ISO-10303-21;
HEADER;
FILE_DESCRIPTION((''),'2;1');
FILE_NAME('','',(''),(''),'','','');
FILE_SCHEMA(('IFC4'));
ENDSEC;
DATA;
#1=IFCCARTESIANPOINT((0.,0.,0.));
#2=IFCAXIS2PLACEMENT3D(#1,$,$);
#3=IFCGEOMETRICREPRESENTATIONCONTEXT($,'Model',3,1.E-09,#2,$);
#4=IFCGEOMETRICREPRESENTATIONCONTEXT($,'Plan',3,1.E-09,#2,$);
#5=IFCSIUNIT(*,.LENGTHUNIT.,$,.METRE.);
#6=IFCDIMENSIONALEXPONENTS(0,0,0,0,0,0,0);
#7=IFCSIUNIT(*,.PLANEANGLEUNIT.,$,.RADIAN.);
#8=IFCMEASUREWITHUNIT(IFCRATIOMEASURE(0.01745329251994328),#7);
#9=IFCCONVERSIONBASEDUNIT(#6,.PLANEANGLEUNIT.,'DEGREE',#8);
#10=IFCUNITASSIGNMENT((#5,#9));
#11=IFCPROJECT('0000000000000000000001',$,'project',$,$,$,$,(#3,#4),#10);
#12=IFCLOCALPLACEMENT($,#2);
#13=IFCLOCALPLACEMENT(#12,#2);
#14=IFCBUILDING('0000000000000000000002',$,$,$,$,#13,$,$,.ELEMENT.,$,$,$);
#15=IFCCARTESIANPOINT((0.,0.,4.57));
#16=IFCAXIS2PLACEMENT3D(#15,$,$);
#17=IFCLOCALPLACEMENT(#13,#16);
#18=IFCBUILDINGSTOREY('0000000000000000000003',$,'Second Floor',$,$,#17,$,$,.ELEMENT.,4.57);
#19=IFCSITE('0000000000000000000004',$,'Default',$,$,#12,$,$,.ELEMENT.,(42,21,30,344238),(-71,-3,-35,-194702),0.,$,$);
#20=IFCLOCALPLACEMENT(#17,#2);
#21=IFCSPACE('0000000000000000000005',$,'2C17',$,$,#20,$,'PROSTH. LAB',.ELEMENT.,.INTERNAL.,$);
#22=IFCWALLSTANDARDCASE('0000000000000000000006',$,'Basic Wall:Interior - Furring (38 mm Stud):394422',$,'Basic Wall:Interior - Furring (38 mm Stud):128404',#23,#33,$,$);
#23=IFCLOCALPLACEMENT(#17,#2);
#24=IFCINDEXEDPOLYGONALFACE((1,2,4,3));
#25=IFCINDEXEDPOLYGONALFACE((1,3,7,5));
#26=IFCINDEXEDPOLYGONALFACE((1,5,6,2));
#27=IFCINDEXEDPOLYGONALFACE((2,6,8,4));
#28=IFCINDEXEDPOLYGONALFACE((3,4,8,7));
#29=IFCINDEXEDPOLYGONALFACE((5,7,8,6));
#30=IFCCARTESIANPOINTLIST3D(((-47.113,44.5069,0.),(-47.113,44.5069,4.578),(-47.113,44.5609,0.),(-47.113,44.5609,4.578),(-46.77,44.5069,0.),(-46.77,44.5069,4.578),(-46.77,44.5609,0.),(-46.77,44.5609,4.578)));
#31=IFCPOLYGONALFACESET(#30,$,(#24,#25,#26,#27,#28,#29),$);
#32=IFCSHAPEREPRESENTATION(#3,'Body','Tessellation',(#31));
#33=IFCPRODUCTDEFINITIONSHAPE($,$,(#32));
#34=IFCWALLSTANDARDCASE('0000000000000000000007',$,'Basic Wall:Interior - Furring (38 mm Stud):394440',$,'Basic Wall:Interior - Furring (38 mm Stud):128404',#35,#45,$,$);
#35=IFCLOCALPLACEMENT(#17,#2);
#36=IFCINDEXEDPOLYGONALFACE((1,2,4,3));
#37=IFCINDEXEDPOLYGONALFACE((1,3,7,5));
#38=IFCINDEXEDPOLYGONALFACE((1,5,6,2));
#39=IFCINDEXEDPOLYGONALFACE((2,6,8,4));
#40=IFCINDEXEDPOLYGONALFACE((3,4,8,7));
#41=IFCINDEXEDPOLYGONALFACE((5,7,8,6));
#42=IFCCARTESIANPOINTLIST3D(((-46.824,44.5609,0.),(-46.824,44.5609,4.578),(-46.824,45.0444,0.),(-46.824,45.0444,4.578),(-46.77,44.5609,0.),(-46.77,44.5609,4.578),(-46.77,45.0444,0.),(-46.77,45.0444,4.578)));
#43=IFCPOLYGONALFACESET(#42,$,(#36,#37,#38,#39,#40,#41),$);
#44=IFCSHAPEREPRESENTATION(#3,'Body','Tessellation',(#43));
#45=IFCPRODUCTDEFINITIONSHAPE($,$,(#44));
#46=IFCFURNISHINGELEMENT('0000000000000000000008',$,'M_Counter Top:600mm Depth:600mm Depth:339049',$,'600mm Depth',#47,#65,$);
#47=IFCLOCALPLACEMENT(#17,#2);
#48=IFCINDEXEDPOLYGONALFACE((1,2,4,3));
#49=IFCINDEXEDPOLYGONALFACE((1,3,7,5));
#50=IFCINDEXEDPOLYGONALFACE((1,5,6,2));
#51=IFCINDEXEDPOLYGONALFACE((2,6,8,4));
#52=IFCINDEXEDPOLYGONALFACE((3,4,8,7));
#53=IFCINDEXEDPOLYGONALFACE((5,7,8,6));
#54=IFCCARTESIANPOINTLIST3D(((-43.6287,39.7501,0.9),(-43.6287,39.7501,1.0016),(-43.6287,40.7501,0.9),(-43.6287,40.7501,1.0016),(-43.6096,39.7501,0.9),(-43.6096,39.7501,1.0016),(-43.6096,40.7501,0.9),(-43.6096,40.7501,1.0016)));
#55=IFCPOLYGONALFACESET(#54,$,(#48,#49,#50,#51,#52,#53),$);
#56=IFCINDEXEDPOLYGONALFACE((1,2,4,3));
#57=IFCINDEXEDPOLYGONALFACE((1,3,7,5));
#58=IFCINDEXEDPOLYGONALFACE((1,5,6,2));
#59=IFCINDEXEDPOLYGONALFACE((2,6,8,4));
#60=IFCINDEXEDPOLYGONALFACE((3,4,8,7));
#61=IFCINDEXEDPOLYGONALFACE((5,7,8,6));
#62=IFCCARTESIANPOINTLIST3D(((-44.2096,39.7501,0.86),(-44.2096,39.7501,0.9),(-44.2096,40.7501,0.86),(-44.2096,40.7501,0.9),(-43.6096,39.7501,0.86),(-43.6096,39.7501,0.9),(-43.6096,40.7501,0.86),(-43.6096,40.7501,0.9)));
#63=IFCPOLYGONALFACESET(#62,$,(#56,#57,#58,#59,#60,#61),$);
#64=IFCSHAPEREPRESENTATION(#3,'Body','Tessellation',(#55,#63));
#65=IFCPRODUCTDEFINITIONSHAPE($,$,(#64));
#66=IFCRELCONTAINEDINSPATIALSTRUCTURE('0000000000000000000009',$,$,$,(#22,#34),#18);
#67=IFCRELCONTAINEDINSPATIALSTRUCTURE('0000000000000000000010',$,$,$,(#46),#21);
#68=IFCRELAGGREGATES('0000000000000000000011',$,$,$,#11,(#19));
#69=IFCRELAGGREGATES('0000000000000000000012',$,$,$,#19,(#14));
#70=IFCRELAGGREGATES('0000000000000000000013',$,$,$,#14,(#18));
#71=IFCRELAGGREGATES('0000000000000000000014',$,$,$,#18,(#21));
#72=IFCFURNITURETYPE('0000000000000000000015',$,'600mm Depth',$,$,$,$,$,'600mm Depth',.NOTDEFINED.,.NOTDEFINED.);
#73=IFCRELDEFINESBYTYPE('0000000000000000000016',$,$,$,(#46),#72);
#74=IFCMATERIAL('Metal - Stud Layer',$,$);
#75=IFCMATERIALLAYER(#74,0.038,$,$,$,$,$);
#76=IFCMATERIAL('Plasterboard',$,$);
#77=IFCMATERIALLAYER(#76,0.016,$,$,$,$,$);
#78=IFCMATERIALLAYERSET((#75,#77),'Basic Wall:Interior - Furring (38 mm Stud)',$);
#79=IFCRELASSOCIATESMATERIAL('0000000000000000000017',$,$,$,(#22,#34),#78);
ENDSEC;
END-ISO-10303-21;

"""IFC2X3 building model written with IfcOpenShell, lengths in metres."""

from ifc_helpers import new_model, entity, si_unit, converted_unit, frame, frame_2d, origin, origin_2d_with_axis, place, context, project, spatial, rectangle, extrude, source, transform, mapped, material, layer, layer_set, layer_usage, type_object, type_shapes, element, save


model = new_model("IFC2X3")

# Units and contexts
model_context = context("Model", 3, precision=1e-09, world=origin())
plan_context = context("Plan", 3, precision=1e-09, world=origin())
ifc_project = project(units=[si_unit("LENGTHUNIT", "METRE"), converted_unit("PLANEANGLEUNIT", "DEGREE", entity("IfcRatioMeasure", 0.01745329251994328), si_unit("PLANEANGLEUNIT", "RADIAN"), dimensions=[0, 0, 0, 0, 0, 0, 0])], contexts=[model_context, plan_context])

# Site, building, storey
site_placement = place(None, origin())
site = spatial("IfcSite", under=ifc_project, at=site_placement, Name="Default", CompositionType="ELEMENT", RefLatitude=(42, 21, 30, 344238), RefLongitude=(-71, -3, -35, -194702), RefElevation=0.0)
building_placement = place(site_placement, origin())
building = spatial("IfcBuilding", under=site, at=building_placement, CompositionType="ELEMENT")
storey_placement = place(building_placement, frame((0.0, 0.0, 4.57)))
storey = spatial("IfcBuildingStorey", under=building, at=storey_placement, Name="Second Floor", CompositionType="ELEMENT", Elevation=4.57)

# Walls
ifc_material_1 = material(Name="Plasterboard")
ifc_layer_1 = layer(ifc_material_1, 0.016)
ifc_material_2 = material(Name="Metal - Stud Layer")
ifc_layer_2 = layer(ifc_material_2, 0.038)
ifc_layer_set_1 = layer_set([ifc_layer_2, ifc_layer_1], Name="Basic Wall:Interior - Furring (38 mm Stud)")
ifc_layer_usage_1 = layer_usage(ifc_layer_set_1, "AXIS2", "NEGATIVE", 0.027)
wall_1_placement = place(storey_placement, frame((-47.113, 44.5339, 0.0)))
element("IfcWallStandardCase", 1, at=wall_1_placement, inside=storey, material=ifc_layer_usage_1, Name="Basic Wall:Interior - Furring (38 mm Stud):394422", ObjectType="Basic Wall:Interior - Furring (38 mm Stud):128404", context=model_context, shape_type="SweptSolid", body=[
    extrude(rectangle(XDim=0.343, YDim=0.054, at=frame_2d((0.1715, 0.0), x_axis=(-1.0, 0.0))), origin(), (0.0, 0.0, 1.0), 4.578),
])
wall_2_placement = place(storey_placement, frame((-46.797, 44.5609, 0.0), z_axis=(0.0, 0.0, 1.0), x_axis=(0.0, 1.0, 0.0)))
element("IfcWallStandardCase", 2, at=wall_2_placement, inside=storey, material=ifc_layer_usage_1, Name="Basic Wall:Interior - Furring (38 mm Stud):394440", ObjectType="Basic Wall:Interior - Furring (38 mm Stud):128404", context=model_context, shape_type="SweptSolid", body=[
    extrude(rectangle(XDim=0.4835, YDim=0.054, at=frame_2d((0.2418, 0.0), x_axis=(-1.0, 0.0))), origin(), (0.0, 0.0, 1.0), 4.578),
])

# Shared definitions
space_placement = place(storey_placement, origin())
space = spatial("IfcSpace", under=storey, at=space_placement, Name="2C17", LongName="PROSTH. LAB", CompositionType="ELEMENT", InteriorOrExteriorSpace="INTERNAL")

# Furnishing element
furniture_type_1 = type_object("IfcFurnitureType", Name="600mm Depth", ElementType="600mm Depth", AssemblyPlace="NOTDEFINED")
shared_shape_1 = source(origin(), model_context, "Body", "SweptSolid", [
    extrude(rectangle(XDim=0.0191, YDim=1.0, at=origin_2d_with_axis()), frame((-0.7005, -0.0095, 0.9), z_axis=(0.0, 0.0, 1.0), x_axis=(0.0, -1.0, 0.0)), (0.0, 0.0, 1.0), 0.1016),
    extrude(rectangle(XDim=1.0, YDim=0.6, at=origin_2d_with_axis()), frame((-0.7005, -0.3, 0.86), z_axis=(0.0, 0.0, 1.0), x_axis=(-1.0, 0.0, 0.0)), (0.0, 0.0, 1.0), 0.04),
])
type_shapes(furniture_type_1, [shared_shape_1])
furnishing_1_placement = place(space_placement, frame((-43.6096, 39.5496, 0.0), z_axis=(0.0, 0.0, 1.0), x_axis=(0.0, -1.0, 0.0)))
element("IfcFurnishingElement", 3, at=furnishing_1_placement, inside=space, type_object=furniture_type_1, Name="M_Counter Top:600mm Depth:600mm Depth:339049", ObjectType="600mm Depth", context=model_context, shape_type="MappedRepresentation", body=[
    mapped(shared_shape_1, transform((0.0, 0.0, 0.0), scale=1.0)),
])

save(model, "model.ifc")
